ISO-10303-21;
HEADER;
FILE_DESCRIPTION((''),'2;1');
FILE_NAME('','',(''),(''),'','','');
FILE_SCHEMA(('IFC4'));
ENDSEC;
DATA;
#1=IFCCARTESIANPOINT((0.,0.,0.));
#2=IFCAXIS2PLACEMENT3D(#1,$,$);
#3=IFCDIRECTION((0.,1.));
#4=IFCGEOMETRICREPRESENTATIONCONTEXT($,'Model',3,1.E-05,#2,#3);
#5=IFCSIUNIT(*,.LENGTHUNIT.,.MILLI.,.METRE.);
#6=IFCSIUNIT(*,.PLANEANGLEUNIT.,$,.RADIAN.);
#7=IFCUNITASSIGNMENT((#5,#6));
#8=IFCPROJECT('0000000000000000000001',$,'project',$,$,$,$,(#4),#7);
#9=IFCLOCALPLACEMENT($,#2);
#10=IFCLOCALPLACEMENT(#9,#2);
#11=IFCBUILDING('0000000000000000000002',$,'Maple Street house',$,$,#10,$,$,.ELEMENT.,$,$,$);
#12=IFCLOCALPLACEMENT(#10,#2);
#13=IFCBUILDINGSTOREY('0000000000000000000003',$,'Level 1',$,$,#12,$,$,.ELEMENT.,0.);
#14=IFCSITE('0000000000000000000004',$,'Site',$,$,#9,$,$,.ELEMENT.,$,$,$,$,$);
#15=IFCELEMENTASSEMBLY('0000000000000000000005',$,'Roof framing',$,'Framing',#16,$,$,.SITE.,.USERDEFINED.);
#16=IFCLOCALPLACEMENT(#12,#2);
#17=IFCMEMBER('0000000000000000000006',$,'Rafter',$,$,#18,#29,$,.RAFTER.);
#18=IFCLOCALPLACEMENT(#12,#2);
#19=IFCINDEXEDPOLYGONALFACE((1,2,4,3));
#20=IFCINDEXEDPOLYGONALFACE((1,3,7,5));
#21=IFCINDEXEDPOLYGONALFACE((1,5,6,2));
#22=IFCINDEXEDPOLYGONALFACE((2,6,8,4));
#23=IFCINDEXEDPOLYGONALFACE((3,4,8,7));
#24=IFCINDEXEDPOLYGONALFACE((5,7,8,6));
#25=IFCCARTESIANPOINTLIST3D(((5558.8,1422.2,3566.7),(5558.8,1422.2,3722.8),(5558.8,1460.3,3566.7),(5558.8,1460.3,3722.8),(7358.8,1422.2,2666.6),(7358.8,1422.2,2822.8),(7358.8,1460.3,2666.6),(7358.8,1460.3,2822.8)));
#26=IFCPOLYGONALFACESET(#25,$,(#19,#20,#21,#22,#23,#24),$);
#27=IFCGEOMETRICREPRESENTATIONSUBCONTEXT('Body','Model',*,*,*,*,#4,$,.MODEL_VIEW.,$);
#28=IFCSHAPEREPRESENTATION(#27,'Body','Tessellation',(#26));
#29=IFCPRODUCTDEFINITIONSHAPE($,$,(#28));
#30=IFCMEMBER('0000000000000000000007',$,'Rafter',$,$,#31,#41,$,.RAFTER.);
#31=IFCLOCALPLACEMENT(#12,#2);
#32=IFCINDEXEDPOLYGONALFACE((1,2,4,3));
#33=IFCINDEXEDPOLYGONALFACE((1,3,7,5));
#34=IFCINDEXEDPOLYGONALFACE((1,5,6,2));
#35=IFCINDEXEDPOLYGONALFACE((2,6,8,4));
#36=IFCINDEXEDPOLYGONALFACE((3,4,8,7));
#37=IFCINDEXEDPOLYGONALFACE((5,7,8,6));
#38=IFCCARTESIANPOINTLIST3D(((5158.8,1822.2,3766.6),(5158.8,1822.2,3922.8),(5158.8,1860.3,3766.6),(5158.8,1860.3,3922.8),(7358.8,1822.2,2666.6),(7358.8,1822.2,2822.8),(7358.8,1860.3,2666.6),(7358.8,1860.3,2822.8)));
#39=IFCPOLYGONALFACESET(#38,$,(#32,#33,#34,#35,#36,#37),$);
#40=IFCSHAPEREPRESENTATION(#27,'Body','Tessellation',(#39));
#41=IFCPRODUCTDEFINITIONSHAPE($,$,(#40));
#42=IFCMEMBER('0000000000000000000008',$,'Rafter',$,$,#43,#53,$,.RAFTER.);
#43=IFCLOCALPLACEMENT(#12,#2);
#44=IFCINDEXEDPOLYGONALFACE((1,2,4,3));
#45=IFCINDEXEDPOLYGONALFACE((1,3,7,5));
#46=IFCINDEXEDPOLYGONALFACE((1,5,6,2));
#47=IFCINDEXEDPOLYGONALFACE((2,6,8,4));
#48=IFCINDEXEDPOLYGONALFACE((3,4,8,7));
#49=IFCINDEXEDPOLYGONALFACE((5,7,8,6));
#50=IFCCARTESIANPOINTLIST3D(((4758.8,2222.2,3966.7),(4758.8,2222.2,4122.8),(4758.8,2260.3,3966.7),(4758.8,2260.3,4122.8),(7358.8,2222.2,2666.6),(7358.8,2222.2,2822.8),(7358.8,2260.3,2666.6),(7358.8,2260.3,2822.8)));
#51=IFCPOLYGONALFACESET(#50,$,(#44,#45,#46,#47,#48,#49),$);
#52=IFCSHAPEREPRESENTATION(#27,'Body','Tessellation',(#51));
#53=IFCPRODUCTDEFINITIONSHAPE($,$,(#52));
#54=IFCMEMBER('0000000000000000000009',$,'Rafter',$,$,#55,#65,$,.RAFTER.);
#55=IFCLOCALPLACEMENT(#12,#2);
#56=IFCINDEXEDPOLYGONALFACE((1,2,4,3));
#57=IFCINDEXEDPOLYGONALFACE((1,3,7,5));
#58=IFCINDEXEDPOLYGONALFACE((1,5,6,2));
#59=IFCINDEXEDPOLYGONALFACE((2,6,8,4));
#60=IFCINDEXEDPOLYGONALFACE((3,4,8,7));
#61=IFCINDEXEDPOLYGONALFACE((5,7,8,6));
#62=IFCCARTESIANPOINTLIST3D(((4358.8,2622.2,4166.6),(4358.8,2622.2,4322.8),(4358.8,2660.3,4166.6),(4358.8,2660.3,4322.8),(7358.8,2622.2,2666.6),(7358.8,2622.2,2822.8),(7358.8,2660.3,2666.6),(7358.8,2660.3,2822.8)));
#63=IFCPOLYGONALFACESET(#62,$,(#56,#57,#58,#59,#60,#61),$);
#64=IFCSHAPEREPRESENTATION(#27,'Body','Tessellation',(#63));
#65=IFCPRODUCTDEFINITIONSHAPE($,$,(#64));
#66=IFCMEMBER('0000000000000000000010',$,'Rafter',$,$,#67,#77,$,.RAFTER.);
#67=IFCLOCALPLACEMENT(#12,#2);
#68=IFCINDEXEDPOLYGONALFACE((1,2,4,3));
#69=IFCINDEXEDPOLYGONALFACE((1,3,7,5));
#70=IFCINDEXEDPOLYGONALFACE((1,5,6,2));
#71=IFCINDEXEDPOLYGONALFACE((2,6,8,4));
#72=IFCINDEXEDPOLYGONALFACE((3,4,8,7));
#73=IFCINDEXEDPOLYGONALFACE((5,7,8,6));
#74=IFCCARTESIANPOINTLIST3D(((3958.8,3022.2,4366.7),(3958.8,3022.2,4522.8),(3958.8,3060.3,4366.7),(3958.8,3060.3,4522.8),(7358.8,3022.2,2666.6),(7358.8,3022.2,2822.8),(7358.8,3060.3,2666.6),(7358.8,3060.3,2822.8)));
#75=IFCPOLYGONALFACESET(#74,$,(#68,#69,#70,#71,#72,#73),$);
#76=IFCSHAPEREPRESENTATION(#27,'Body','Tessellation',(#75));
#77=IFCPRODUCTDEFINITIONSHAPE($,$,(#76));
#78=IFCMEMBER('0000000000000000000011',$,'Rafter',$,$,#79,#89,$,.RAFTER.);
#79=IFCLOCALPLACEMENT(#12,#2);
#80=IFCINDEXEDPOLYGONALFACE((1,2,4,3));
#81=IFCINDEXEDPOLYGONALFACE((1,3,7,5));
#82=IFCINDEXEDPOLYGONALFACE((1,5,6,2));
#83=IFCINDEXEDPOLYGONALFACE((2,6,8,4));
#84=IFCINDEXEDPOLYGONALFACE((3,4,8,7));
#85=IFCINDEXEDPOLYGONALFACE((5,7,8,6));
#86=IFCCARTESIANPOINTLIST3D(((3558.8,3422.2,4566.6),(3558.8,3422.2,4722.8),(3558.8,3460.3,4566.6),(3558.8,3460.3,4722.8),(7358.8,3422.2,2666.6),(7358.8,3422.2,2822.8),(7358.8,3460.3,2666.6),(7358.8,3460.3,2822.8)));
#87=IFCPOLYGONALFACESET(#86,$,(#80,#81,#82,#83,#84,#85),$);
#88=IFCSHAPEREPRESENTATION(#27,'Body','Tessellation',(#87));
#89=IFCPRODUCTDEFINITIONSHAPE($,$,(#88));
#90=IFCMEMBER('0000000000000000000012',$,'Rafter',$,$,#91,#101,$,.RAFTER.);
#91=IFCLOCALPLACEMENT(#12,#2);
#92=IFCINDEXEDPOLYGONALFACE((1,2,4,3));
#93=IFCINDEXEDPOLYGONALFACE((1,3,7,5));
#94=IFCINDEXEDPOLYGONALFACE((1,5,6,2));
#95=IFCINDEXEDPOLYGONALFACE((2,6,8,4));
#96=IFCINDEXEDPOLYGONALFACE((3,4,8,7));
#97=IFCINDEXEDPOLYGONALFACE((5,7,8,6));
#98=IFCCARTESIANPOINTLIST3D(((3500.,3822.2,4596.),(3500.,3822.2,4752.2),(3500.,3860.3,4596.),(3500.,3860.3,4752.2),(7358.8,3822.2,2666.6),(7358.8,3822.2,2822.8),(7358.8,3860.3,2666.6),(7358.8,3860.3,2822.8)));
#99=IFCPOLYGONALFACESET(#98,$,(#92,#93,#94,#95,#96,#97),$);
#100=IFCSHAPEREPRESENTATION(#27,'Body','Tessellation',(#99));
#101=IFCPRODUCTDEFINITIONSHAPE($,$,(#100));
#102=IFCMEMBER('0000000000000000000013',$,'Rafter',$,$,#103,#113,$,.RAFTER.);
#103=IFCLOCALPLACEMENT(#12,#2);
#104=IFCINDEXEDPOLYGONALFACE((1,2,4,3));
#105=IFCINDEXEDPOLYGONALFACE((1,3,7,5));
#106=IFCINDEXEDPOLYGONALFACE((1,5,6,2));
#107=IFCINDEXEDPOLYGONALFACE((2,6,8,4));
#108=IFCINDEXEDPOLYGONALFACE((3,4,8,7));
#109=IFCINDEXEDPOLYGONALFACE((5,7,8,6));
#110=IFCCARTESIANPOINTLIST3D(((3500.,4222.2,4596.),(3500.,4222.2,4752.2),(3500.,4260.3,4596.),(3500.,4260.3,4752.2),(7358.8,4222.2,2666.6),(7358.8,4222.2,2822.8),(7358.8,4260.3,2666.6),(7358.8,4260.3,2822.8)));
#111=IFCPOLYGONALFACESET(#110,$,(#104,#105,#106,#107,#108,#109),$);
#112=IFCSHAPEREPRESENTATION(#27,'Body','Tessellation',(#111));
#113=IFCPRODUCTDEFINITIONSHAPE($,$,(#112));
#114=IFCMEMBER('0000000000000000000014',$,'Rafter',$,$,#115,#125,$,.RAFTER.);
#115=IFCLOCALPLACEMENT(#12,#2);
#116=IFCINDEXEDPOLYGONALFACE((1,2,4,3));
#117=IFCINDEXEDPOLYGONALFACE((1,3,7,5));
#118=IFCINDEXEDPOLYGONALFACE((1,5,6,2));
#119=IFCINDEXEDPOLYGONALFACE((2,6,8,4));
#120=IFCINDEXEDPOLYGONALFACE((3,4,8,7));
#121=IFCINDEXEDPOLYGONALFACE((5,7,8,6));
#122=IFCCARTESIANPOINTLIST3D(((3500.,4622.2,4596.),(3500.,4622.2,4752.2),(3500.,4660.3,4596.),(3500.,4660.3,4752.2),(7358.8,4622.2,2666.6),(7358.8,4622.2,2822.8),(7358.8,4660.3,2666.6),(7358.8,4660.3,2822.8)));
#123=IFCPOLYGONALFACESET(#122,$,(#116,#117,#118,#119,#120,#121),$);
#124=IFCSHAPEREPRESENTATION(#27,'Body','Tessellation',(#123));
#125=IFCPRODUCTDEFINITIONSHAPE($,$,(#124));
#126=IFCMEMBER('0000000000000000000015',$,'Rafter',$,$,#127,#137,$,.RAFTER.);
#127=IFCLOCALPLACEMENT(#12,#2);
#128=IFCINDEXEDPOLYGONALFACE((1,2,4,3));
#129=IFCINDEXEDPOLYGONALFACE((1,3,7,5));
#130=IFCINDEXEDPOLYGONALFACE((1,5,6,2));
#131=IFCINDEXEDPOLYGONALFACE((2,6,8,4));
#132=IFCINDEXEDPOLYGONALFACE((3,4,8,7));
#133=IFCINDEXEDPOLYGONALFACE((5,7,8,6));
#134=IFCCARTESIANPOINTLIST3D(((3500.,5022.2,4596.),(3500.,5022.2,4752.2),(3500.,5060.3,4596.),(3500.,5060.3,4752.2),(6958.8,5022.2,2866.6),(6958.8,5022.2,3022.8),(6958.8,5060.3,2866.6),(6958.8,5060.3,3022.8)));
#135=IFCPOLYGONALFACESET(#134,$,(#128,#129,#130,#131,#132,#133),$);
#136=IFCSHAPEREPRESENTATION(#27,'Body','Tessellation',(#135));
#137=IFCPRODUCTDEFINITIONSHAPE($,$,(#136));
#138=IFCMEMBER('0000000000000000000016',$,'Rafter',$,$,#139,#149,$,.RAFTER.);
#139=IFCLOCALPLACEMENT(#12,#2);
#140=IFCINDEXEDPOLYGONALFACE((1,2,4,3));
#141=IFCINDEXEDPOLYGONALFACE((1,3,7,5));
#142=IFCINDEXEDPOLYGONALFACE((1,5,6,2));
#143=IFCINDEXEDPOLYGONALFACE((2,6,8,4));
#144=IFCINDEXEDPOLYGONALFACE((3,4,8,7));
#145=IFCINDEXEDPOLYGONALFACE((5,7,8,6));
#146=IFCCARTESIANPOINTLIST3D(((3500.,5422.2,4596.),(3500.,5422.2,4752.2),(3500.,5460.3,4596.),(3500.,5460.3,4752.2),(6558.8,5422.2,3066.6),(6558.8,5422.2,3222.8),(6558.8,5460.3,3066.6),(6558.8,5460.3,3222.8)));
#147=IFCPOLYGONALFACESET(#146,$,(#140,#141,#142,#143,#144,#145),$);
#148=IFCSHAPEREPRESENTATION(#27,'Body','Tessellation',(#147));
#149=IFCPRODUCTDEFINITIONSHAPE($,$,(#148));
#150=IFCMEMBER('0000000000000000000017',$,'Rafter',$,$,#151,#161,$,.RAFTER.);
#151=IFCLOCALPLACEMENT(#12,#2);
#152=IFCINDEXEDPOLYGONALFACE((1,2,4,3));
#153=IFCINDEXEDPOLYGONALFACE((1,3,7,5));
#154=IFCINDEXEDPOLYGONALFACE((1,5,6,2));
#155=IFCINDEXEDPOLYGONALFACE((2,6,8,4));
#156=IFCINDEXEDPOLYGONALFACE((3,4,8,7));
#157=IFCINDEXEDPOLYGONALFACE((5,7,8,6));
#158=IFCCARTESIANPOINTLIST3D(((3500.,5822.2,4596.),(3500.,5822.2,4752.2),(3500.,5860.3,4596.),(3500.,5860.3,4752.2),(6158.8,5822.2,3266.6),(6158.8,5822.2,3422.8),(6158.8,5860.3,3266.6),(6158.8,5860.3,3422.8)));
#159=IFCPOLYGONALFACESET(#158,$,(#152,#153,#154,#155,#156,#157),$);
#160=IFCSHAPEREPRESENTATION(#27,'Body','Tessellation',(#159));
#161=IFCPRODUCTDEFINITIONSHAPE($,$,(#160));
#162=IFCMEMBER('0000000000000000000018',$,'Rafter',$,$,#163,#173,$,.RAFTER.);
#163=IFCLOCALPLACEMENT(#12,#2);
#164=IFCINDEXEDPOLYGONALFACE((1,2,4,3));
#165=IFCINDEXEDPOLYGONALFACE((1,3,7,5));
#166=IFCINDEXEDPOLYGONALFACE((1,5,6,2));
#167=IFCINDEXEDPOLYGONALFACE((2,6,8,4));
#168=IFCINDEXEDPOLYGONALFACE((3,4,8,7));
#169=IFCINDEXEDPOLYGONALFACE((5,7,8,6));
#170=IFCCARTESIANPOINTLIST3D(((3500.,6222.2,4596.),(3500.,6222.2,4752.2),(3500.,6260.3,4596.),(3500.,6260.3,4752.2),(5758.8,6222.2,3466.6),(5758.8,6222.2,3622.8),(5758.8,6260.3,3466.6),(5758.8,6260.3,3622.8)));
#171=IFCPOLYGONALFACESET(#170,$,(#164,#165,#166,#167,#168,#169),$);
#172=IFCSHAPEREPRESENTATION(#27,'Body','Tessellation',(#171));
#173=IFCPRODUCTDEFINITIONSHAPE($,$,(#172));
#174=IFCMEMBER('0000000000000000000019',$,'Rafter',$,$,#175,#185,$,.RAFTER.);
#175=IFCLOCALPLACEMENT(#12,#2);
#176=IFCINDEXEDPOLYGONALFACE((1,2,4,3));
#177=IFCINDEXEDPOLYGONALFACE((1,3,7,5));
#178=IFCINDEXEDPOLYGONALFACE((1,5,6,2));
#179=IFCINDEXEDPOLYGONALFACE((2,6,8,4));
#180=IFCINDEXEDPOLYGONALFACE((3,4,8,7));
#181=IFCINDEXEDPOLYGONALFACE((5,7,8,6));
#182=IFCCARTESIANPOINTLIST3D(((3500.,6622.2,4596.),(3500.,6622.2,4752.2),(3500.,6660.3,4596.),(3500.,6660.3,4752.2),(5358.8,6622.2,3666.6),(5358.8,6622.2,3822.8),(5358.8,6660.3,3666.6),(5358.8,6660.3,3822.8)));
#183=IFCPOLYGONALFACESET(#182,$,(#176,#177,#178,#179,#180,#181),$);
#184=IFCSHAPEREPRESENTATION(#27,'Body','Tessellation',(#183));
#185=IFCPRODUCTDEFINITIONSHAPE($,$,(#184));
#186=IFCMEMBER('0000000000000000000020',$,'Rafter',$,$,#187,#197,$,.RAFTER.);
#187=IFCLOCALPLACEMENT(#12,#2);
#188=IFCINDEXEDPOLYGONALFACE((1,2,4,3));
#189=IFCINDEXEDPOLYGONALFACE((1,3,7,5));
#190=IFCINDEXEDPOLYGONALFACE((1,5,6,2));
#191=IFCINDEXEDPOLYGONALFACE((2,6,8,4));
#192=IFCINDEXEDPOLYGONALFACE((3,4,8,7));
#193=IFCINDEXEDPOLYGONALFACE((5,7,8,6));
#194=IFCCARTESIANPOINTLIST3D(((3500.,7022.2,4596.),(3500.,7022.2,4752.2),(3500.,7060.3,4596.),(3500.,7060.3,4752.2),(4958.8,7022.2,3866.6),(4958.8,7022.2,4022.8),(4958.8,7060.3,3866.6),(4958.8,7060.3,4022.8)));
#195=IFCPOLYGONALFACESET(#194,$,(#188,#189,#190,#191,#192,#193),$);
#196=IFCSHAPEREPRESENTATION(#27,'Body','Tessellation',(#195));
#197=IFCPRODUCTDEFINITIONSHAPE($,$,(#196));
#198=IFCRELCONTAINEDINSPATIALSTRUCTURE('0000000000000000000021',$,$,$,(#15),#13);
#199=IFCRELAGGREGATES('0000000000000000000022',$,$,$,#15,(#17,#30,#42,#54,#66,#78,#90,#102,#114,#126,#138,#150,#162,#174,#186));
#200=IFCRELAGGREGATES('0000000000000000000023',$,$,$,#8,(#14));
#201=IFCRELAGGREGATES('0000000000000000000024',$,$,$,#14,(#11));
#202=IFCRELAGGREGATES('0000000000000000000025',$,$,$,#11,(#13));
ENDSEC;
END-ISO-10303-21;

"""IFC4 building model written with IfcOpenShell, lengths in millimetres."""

from ifc_helpers import new_model, si_unit, direction, frame, origin, origin_with_axes, place, context, subcontext, project, spatial, polyline, outline, extrude, element, aggregate, save


model = new_model("IFC4")

# Units and contexts
model_context = context("Model", 3, precision=1e-05, world=origin(), true_north=direction((0.0, 1.0)))
body_context = subcontext(model_context, "Body", "Model", "MODEL_VIEW")
ifc_project = project(units=[si_unit("LENGTHUNIT", "METRE", prefix="MILLI"), si_unit("PLANEANGLEUNIT", "RADIAN")], contexts=[model_context])

# Site, building, storey
site_placement = place(None, origin())
site = spatial("IfcSite", under=ifc_project, at=site_placement, Name="Site", CompositionType="ELEMENT")
building_placement = place(site_placement, origin())
building = spatial("IfcBuilding", under=site, at=building_placement, Name="Maple Street house", CompositionType="ELEMENT")
storey_placement = place(building_placement, origin())
storey = spatial("IfcBuildingStorey", under=building, at=storey_placement, Name="Level 1", CompositionType="ELEMENT", Elevation=0.0)

# Element assembly, members
assembly_placement = place(storey_placement, origin_with_axes())
assembly = element("IfcElementAssembly", 1, at=assembly_placement, inside=storey, Name="Roof framing", ObjectType="Framing", AssemblyPlace="SITE", PredefinedType="USERDEFINED")
member_1_placement = place(storey_placement, origin_with_axes())
member_1 = element("IfcMember", 2, at=member_1_placement, Name="Rafter", PredefinedType="RAFTER", context=body_context, shape_type="SweptSolid", body=[
    extrude(outline(polyline([(0.0, 0.0), (38.1, 0.0), (38.1, 156.2), (0.0, 156.2), (0.0, 0.0)])), frame((7358.8, 1460.3, 2666.7), z_axis=(-1.0, 0.0, 0.0), x_axis=(0.0, -1.0, 0.0)), (0.0, 0.447214, 0.894427), 2012.5),
])
member_2_placement = place(storey_placement, origin_with_axes())
member_2 = element("IfcMember", 3, at=member_2_placement, Name="Rafter", PredefinedType="RAFTER", context=body_context, shape_type="SweptSolid", body=[
    extrude(outline(polyline([(0.0, 0.0), (38.1, 0.0), (38.1, 156.2), (0.0, 156.2), (0.0, 0.0)])), frame((7358.8, 1860.3, 2666.7), z_axis=(-1.0, 0.0, 0.0), x_axis=(0.0, -1.0, 0.0)), (0.0, 0.447214, 0.894427), 2459.7),
])
member_3_placement = place(storey_placement, origin_with_axes())
member_3 = element("IfcMember", 4, at=member_3_placement, Name="Rafter", PredefinedType="RAFTER", context=body_context, shape_type="SweptSolid", body=[
    extrude(outline(polyline([(0.0, 0.0), (38.1, 0.0), (38.1, 156.2), (0.0, 156.2), (0.0, 0.0)])), frame((7358.8, 2260.3, 2666.7), z_axis=(-1.0, 0.0, 0.0), x_axis=(0.0, -1.0, 0.0)), (0.0, 0.447214, 0.894427), 2906.9),
])
member_4_placement = place(storey_placement, origin_with_axes())
member_4 = element("IfcMember", 5, at=member_4_placement, Name="Rafter", PredefinedType="RAFTER", context=body_context, shape_type="SweptSolid", body=[
    extrude(outline(polyline([(0.0, 0.0), (38.1, 0.0), (38.1, 156.2), (0.0, 156.2), (0.0, 0.0)])), frame((7358.8, 2660.3, 2666.7), z_axis=(-1.0, 0.0, 0.0), x_axis=(0.0, -1.0, 0.0)), (0.0, 0.447214, 0.894427), 3354.1),
])
member_5_placement = place(storey_placement, origin_with_axes())
member_5 = element("IfcMember", 6, at=member_5_placement, Name="Rafter", PredefinedType="RAFTER", context=body_context, shape_type="SweptSolid", body=[
    extrude(outline(polyline([(0.0, 0.0), (38.1, 0.0), (38.1, 156.2), (0.0, 156.2), (0.0, 0.0)])), frame((7358.8, 3060.3, 2666.7), z_axis=(-1.0, 0.0, 0.0), x_axis=(0.0, -1.0, 0.0)), (0.0, 0.447214, 0.894427), 3801.3),
])
member_6_placement = place(storey_placement, origin_with_axes())
member_6 = element("IfcMember", 7, at=member_6_placement, Name="Rafter", PredefinedType="RAFTER", context=body_context, shape_type="SweptSolid", body=[
    extrude(outline(polyline([(0.0, 0.0), (38.1, 0.0), (38.1, 156.2), (0.0, 156.2), (0.0, 0.0)])), frame((7358.8, 3460.3, 2666.7), z_axis=(-1.0, 0.0, 0.0), x_axis=(0.0, -1.0, 0.0)), (0.0, 0.447214, 0.894427), 4248.5),
])
member_7_placement = place(storey_placement, origin_with_axes())
member_7 = element("IfcMember", 8, at=member_7_placement, Name="Rafter", PredefinedType="RAFTER", context=body_context, shape_type="SweptSolid", body=[
    extrude(outline(polyline([(0.0, 0.0), (38.1, 0.0), (38.1, 156.2), (0.0, 156.2), (0.0, 0.0)])), frame((7358.8, 3860.3, 2666.7), z_axis=(-1.0, 0.0, 0.0), x_axis=(0.0, -1.0, 0.0)), (0.0, 0.447214, 0.894427), 4314.2),
])
member_8_placement = place(storey_placement, origin_with_axes())
member_8 = element("IfcMember", 9, at=member_8_placement, Name="Rafter", PredefinedType="RAFTER", context=body_context, shape_type="SweptSolid", body=[
    extrude(outline(polyline([(0.0, 0.0), (38.1, 0.0), (38.1, 156.2), (0.0, 156.2), (0.0, 0.0)])), frame((7358.8, 4260.3, 2666.7), z_axis=(-1.0, 0.0, 0.0), x_axis=(0.0, -1.0, 0.0)), (0.0, 0.447214, 0.894427), 4314.2),
])
member_9_placement = place(storey_placement, origin_with_axes())
member_9 = element("IfcMember", 10, at=member_9_placement, Name="Rafter", PredefinedType="RAFTER", context=body_context, shape_type="SweptSolid", body=[
    extrude(outline(polyline([(0.0, 0.0), (38.1, 0.0), (38.1, 156.2), (0.0, 156.2), (0.0, 0.0)])), frame((7358.8, 4660.3, 2666.7), z_axis=(-1.0, 0.0, 0.0), x_axis=(0.0, -1.0, 0.0)), (0.0, 0.447214, 0.894427), 4314.2),
])
member_10_placement = place(storey_placement, origin_with_axes())
member_10 = element("IfcMember", 11, at=member_10_placement, Name="Rafter", PredefinedType="RAFTER", context=body_context, shape_type="SweptSolid", body=[
    extrude(outline(polyline([(0.0, 0.0), (38.1, 0.0), (38.1, 156.2), (0.0, 156.2), (0.0, 0.0)])), frame((6958.8, 5060.3, 2866.7), z_axis=(-1.0, 0.0, 0.0), x_axis=(0.0, -1.0, 0.0)), (0.0, 0.447214, 0.894427), 3867.0),
])
member_11_placement = place(storey_placement, origin_with_axes())
member_11 = element("IfcMember", 12, at=member_11_placement, Name="Rafter", PredefinedType="RAFTER", context=body_context, shape_type="SweptSolid", body=[
    extrude(outline(polyline([(0.0, 0.0), (38.1, 0.0), (38.1, 156.2), (0.0, 156.2), (0.0, 0.0)])), frame((6558.8, 5460.3, 3066.7), z_axis=(-1.0, 0.0, 0.0), x_axis=(0.0, -1.0, 0.0)), (0.0, 0.447214, 0.894427), 3419.8),
])
member_12_placement = place(storey_placement, origin_with_axes())
member_12 = element("IfcMember", 13, at=member_12_placement, Name="Rafter", PredefinedType="RAFTER", context=body_context, shape_type="SweptSolid", body=[
    extrude(outline(polyline([(0.0, 0.0), (38.1, 0.0), (38.1, 156.2), (0.0, 156.2), (0.0, 0.0)])), frame((6158.8, 5860.3, 3266.7), z_axis=(-1.0, 0.0, 0.0), x_axis=(0.0, -1.0, 0.0)), (0.0, 0.447214, 0.894427), 2972.6),
])
member_13_placement = place(storey_placement, origin_with_axes())
member_13 = element("IfcMember", 14, at=member_13_placement, Name="Rafter", PredefinedType="RAFTER", context=body_context, shape_type="SweptSolid", body=[
    extrude(outline(polyline([(0.0, 0.0), (38.1, 0.0), (38.1, 156.2), (0.0, 156.2), (0.0, 0.0)])), frame((5758.8, 6260.3, 3466.7), z_axis=(-1.0, 0.0, 0.0), x_axis=(0.0, -1.0, 0.0)), (0.0, 0.447214, 0.894427), 2525.4),
])
member_14_placement = place(storey_placement, origin_with_axes())
member_14 = element("IfcMember", 15, at=member_14_placement, Name="Rafter", PredefinedType="RAFTER", context=body_context, shape_type="SweptSolid", body=[
    extrude(outline(polyline([(0.0, 0.0), (38.1, 0.0), (38.1, 156.2), (0.0, 156.2), (0.0, 0.0)])), frame((5358.8, 6660.3, 3666.7), z_axis=(-1.0, 0.0, 0.0), x_axis=(0.0, -1.0, 0.0)), (0.0, 0.447214, 0.894427), 2078.2),
])
member_15_placement = place(storey_placement, origin_with_axes())
member_15 = element("IfcMember", 16, at=member_15_placement, Name="Rafter", PredefinedType="RAFTER", context=body_context, shape_type="SweptSolid", body=[
    extrude(outline(polyline([(0.0, 0.0), (38.1, 0.0), (38.1, 156.2), (0.0, 156.2), (0.0, 0.0)])), frame((4958.8, 7060.3, 3866.7), z_axis=(-1.0, 0.0, 0.0), x_axis=(0.0, -1.0, 0.0)), (0.0, 0.447214, 0.894427), 1631.0),
])
aggregate(assembly, [member_1, member_2, member_3, member_4, member_5, member_6, member_7, member_8, member_9, member_10, member_11, member_12, member_13, member_14, member_15])

save(model, "model.ifc")
